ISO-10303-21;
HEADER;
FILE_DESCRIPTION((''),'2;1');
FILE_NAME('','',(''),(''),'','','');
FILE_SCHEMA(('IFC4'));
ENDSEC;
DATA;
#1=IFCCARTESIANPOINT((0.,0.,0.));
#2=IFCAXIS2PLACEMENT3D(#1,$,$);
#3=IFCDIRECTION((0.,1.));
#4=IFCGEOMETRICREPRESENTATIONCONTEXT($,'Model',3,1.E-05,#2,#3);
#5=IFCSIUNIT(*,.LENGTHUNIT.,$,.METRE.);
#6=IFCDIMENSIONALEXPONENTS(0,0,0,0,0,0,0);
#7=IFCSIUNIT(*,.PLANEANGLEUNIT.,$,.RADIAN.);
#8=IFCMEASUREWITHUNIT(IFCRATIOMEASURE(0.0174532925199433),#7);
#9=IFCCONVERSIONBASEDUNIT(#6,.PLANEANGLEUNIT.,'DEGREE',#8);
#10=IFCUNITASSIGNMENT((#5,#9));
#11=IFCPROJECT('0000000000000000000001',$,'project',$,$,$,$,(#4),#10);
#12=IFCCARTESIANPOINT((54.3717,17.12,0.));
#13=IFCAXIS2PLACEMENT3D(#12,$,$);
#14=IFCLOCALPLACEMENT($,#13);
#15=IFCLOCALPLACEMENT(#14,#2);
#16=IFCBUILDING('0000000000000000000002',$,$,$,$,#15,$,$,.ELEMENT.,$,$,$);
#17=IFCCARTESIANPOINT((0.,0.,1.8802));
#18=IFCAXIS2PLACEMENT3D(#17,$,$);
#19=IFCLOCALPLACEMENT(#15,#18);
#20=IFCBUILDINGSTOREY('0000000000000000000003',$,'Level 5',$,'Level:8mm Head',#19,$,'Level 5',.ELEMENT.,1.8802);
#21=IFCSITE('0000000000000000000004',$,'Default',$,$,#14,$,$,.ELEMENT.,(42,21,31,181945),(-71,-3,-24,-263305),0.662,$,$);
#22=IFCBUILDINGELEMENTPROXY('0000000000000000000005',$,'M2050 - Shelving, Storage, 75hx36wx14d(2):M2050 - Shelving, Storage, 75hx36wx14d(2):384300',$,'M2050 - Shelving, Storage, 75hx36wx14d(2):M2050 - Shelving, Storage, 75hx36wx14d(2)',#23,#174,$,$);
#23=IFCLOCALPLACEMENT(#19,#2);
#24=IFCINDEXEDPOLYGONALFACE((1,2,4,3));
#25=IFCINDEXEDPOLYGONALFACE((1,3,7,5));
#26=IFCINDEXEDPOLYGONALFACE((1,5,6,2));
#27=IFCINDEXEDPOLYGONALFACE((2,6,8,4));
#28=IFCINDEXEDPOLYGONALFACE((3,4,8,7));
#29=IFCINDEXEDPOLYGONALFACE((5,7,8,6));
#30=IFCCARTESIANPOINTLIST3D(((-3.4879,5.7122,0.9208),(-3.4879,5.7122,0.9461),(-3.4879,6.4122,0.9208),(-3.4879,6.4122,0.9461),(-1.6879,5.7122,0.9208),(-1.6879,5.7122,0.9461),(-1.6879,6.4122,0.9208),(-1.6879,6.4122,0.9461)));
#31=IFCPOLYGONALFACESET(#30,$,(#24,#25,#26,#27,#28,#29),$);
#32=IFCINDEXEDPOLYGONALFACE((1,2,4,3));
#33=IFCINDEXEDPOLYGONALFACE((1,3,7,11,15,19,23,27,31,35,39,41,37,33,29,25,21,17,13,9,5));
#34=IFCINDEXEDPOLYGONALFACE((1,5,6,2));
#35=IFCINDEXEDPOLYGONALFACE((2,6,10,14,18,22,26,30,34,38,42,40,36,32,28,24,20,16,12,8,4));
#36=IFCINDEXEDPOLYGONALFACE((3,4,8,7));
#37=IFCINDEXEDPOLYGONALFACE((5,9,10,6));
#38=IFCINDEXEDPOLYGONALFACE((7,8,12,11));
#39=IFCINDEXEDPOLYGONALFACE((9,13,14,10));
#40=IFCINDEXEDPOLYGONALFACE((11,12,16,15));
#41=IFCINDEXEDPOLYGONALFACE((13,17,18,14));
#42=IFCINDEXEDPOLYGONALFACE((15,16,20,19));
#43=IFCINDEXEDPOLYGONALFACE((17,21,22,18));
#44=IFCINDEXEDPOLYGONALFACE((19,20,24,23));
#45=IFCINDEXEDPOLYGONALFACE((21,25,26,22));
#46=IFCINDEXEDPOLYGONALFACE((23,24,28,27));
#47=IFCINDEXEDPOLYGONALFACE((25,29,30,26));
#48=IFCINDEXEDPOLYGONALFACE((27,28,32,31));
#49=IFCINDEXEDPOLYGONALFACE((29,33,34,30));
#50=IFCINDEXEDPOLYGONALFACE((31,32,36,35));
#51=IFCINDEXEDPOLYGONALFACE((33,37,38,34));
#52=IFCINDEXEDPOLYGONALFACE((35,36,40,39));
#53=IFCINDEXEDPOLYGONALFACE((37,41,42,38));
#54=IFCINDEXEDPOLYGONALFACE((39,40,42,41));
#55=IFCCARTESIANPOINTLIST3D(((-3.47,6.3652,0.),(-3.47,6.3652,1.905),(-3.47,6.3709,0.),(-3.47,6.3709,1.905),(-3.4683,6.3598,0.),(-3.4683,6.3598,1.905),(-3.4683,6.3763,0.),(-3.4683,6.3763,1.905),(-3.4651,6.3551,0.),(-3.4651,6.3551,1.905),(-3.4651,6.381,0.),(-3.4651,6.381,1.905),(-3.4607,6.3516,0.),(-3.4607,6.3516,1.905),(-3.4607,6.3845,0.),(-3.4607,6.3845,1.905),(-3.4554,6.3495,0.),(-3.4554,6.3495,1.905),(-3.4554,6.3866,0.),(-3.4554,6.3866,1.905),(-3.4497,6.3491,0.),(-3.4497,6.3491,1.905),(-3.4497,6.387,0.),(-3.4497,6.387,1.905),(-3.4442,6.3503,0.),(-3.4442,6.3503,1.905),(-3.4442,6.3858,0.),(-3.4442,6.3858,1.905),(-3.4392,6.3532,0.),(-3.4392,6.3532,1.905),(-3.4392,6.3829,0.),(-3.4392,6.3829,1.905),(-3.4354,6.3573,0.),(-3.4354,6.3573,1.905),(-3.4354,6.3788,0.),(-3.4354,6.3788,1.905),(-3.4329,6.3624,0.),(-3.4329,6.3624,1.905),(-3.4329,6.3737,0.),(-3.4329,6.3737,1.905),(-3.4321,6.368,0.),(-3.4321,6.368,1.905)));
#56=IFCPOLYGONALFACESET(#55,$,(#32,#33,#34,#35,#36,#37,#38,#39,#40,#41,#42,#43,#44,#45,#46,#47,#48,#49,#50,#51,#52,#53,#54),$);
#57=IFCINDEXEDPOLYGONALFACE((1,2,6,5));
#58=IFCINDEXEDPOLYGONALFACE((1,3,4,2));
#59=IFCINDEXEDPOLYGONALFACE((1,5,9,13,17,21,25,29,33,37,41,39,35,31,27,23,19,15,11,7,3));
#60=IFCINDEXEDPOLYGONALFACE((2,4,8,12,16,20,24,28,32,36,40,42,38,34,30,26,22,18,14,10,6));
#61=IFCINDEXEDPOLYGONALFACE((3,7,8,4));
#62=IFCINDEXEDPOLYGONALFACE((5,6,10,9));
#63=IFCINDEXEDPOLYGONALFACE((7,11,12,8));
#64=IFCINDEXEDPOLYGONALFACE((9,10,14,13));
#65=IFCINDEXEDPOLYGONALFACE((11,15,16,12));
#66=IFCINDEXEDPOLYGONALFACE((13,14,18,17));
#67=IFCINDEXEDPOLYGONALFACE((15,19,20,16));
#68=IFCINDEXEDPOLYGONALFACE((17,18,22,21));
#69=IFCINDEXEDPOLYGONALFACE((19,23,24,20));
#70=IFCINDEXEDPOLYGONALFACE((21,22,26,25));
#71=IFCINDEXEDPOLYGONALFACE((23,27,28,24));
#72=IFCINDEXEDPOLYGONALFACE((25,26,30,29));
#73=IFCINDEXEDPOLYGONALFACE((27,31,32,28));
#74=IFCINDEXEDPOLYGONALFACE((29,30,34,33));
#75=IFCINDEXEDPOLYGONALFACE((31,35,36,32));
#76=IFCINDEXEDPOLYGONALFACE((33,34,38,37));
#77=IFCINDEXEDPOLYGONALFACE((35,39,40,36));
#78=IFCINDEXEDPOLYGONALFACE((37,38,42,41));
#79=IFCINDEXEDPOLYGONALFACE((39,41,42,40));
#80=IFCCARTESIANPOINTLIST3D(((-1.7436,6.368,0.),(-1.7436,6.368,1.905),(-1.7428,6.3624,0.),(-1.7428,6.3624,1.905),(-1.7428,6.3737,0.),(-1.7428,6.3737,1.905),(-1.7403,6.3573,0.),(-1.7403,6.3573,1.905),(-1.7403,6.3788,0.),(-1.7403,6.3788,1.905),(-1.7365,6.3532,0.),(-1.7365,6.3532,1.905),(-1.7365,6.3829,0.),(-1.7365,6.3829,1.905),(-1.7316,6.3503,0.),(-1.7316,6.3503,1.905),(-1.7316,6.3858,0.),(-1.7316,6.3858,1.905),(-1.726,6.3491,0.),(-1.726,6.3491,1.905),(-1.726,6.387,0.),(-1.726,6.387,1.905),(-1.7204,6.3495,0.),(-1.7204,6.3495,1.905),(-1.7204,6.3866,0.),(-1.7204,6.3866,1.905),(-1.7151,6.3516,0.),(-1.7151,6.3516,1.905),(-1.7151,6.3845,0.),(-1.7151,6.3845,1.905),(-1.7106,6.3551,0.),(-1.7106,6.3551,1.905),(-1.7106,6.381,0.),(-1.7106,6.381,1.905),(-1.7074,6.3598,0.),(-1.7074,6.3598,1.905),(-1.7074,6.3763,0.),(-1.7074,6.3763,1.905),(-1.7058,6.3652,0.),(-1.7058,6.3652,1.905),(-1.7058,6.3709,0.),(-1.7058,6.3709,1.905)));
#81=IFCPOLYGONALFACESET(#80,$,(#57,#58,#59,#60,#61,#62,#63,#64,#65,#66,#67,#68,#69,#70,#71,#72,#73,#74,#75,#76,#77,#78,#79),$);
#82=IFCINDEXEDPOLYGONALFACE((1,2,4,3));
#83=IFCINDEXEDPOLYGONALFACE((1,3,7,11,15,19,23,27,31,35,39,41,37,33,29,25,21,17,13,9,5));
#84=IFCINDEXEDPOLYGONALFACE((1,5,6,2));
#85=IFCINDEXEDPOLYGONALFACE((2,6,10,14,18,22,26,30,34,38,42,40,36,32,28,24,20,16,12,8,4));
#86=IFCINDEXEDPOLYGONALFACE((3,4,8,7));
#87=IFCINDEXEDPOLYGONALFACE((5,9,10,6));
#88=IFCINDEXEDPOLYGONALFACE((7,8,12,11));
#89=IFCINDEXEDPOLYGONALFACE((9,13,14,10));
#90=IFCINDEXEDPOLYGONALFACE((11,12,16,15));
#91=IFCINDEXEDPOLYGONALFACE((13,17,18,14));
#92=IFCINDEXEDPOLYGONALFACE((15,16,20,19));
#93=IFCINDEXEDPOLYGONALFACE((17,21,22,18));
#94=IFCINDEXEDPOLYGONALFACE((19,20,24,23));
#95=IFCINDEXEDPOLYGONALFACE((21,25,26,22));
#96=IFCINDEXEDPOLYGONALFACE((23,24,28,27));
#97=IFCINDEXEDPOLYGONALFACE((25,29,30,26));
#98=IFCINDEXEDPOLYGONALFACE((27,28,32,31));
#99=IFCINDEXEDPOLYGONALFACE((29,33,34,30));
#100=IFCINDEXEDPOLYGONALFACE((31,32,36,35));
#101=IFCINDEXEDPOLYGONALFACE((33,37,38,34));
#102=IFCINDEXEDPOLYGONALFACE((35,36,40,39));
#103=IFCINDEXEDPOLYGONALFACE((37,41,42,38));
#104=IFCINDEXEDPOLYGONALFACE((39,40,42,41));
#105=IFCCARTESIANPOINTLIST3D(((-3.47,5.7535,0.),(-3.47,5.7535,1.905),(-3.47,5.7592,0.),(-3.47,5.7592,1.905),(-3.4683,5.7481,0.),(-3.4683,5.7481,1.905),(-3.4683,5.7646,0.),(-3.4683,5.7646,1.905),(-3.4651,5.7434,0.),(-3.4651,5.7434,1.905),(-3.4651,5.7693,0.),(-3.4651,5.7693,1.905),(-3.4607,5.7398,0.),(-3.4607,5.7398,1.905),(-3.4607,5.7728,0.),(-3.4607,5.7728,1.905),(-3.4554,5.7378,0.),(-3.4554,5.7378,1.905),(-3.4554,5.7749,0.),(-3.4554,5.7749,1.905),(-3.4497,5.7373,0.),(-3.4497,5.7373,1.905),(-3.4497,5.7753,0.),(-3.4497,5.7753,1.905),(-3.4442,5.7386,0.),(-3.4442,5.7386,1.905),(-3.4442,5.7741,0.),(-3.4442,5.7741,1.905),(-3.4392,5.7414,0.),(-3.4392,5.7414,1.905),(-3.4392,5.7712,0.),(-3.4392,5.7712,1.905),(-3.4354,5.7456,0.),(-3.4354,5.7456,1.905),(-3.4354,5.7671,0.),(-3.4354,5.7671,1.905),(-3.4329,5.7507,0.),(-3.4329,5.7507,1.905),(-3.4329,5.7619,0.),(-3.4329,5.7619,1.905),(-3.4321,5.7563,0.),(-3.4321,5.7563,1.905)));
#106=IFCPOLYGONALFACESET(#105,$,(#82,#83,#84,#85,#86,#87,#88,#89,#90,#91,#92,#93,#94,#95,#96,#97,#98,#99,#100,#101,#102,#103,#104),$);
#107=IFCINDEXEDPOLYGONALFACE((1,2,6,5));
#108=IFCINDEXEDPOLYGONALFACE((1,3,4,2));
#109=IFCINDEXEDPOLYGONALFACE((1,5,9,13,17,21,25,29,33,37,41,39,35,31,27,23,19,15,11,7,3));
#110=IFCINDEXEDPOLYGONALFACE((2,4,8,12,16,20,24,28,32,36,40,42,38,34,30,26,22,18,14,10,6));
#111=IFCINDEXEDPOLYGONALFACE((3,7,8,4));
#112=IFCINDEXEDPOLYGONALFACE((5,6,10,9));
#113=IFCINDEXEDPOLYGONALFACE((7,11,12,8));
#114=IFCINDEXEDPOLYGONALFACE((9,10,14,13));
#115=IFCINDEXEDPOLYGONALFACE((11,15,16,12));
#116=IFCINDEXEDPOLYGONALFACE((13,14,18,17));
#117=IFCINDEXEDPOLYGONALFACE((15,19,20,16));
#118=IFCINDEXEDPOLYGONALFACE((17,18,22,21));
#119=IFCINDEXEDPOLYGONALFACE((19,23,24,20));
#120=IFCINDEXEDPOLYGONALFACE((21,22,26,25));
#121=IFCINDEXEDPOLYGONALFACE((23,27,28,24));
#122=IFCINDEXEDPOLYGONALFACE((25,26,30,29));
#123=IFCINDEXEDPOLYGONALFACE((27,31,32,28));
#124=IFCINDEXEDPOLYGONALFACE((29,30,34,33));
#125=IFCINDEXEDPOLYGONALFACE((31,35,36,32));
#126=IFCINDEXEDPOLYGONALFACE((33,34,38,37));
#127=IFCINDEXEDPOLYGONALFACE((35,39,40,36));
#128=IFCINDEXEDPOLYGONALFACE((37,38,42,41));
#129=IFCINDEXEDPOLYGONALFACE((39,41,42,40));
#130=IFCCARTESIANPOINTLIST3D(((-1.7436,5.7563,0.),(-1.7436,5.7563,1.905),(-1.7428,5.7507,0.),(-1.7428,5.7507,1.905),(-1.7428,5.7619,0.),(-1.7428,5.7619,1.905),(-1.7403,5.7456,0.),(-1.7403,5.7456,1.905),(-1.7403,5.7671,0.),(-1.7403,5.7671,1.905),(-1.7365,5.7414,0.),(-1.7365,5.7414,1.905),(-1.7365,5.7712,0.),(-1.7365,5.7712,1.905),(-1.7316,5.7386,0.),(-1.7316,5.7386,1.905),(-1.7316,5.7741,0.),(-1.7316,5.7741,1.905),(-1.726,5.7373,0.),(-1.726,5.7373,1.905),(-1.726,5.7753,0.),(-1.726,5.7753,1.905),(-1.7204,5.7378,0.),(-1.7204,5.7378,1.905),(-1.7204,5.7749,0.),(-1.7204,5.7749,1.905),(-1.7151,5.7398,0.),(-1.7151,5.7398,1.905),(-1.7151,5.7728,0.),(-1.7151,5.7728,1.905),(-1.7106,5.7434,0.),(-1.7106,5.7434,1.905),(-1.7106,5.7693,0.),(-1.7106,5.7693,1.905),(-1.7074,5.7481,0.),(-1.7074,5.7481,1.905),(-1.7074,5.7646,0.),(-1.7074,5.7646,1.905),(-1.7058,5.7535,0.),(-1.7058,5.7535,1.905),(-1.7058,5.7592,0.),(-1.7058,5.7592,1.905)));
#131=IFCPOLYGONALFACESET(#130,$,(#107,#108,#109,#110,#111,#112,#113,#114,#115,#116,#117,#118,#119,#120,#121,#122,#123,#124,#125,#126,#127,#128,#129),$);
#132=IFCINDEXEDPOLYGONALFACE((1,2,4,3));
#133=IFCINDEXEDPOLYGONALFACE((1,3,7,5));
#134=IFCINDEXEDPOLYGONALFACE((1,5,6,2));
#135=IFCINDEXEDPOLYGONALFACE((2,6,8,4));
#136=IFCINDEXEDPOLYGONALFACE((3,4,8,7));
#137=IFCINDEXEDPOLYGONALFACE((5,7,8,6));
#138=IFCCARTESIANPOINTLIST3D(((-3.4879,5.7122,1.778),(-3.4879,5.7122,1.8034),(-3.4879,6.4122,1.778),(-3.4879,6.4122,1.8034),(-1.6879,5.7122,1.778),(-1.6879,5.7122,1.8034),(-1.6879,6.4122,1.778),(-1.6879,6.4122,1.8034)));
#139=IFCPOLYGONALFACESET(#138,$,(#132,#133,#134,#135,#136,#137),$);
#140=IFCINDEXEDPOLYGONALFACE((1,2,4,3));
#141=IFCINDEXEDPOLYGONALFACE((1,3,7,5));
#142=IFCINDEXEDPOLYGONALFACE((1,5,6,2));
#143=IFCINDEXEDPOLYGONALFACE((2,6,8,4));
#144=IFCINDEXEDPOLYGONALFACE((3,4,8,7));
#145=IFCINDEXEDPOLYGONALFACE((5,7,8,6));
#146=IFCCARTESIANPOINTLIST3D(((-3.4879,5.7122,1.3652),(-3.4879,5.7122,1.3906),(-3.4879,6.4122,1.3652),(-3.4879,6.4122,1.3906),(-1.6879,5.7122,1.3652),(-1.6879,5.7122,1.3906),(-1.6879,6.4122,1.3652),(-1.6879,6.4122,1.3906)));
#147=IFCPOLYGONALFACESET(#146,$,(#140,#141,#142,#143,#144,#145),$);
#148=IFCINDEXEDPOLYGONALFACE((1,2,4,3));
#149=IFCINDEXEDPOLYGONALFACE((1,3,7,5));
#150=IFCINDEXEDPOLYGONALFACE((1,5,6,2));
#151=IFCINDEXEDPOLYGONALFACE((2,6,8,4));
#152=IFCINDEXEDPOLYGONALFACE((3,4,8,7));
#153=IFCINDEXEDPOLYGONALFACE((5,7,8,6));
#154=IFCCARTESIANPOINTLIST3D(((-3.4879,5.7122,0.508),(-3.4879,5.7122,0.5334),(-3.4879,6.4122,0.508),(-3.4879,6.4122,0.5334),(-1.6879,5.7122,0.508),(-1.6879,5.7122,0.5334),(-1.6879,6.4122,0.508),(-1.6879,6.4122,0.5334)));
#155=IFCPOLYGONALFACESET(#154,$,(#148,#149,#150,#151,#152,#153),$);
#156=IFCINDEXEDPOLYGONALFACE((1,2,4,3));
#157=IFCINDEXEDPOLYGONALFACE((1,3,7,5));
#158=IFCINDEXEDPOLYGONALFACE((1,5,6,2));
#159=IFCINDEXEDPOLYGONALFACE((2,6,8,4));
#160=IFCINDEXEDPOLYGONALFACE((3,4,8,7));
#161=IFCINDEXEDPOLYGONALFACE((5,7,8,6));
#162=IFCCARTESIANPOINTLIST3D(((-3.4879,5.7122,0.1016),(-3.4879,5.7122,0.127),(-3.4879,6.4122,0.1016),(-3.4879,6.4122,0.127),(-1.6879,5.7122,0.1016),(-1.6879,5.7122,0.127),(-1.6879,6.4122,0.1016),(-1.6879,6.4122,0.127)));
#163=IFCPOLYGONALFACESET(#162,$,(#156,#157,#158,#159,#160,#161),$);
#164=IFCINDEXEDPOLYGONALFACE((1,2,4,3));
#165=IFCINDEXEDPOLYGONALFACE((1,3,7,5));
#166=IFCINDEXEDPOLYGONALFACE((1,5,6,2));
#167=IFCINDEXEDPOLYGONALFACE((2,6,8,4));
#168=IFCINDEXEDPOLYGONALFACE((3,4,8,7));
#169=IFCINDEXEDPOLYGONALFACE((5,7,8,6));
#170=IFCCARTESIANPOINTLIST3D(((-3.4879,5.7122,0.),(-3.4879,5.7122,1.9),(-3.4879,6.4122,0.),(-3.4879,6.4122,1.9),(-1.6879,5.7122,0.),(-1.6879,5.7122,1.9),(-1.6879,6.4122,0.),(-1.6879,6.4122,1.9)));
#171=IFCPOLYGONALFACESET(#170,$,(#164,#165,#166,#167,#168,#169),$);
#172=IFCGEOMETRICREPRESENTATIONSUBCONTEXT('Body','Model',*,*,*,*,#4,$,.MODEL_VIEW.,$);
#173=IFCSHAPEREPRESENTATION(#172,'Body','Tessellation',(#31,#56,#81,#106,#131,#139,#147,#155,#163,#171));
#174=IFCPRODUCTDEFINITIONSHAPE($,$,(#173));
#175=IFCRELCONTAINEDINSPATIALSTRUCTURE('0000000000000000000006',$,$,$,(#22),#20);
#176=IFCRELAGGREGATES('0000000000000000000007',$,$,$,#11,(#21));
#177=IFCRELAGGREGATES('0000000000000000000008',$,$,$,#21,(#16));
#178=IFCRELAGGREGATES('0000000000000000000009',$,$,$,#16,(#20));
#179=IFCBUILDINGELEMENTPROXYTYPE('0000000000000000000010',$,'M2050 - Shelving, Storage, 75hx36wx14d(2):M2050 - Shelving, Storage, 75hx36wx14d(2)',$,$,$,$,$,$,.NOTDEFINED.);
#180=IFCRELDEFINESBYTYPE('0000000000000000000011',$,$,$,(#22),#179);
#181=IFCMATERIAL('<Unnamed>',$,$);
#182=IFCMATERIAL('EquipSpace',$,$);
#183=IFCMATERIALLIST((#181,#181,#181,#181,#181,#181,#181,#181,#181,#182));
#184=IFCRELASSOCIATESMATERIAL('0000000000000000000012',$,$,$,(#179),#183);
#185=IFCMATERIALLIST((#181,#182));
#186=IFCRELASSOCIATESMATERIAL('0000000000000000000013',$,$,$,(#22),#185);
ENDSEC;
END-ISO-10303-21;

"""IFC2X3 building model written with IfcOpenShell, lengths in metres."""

from ifc_helpers import new_model, entity, si_unit, converted_unit, direction, frame, frame_2d, origin, origin_2d_with_axis, place, context, subcontext, project, spatial, rectangle, circle, extrude, source, transform, mapped, material, material_list, type_object, type_shapes, element, save


model = new_model("IFC2X3")

# Units and contexts
model_context = context("Model", 3, precision=1e-05, world=origin(), true_north=direction((0.0, 1.0)))
body_context = subcontext(model_context, "Body", "Model", "MODEL_VIEW")
ifc_project = project(units=[si_unit("LENGTHUNIT", "METRE"), converted_unit("PLANEANGLEUNIT", "DEGREE", entity("IfcRatioMeasure", 0.0174532925199433), si_unit("PLANEANGLEUNIT", "RADIAN"), dimensions=[0, 0, 0, 0, 0, 0, 0])], contexts=[model_context])

# Site, building, storey
site_placement = place(None, frame((54.3717, 17.12, 0.0)))
site = spatial("IfcSite", under=ifc_project, at=site_placement, Name="Default", CompositionType="ELEMENT", RefLatitude=(42, 21, 31, 181945), RefLongitude=(-71, -3, -24, -263305), RefElevation=0.662)
building_placement = place(site_placement, origin())
building = spatial("IfcBuilding", under=site, at=building_placement, CompositionType="ELEMENT")
storey_placement = place(building_placement, frame((0.0, 0.0, 1.8802)))
storey = spatial("IfcBuildingStorey", under=building, at=storey_placement, Name="Level 5", ObjectType="Level:8mm Head", LongName="Level 5", CompositionType="ELEMENT", Elevation=1.8802)

# Building element proxy
ifc_material_1 = material(Name="<Unnamed>")
ifc_material_2 = material(Name="EquipSpace")
ifc_material_list_1 = material_list([ifc_material_1, ifc_material_1, ifc_material_1, ifc_material_1, ifc_material_1, ifc_material_1, ifc_material_1, ifc_material_1, ifc_material_1, ifc_material_2])
building_element_proxy_type = type_object("IfcBuildingElementProxyType", Name="M2050 - Shelving, Storage, 75hx36wx14d(2):M2050 - Shelving, Storage, 75hx36wx14d(2)", PredefinedType="NOTDEFINED", material=ifc_material_list_1)
shared_shape = source(origin(), body_context, "Body", "SweptSolid", [
    extrude(rectangle(XDim=1.8, YDim=0.7, at=origin_2d_with_axis()), frame((0.0, 0.0, 0.9207), z_axis=(0.0, 0.0, 1.0), x_axis=(-1.0, 0.0, 0.0)), (0.0, 0.0, 1.0), 0.0254),
    extrude(circle(Radius=0.0191, at=origin_2d_with_axis()), frame((0.8633, -0.3059, 0.0), z_axis=(0.0, 0.0, 1.0), x_axis=(-1.0, 0.0, 0.0)), (0.0, 0.0, 1.0), 1.905),
    extrude(circle(Radius=0.0191, at=origin_2d_with_axis()), frame((-0.8633, -0.3059, 0.0)), (0.0, 0.0, 1.0), 1.905),
    extrude(circle(Radius=0.0191, at=origin_2d_with_axis()), frame((0.8633, 0.3059, 0.0), z_axis=(0.0, 0.0, 1.0), x_axis=(-1.0, 0.0, 0.0)), (0.0, 0.0, 1.0), 1.905),
    extrude(circle(Radius=0.0191, at=origin_2d_with_axis()), frame((-0.8633, 0.3059, 0.0)), (0.0, 0.0, 1.0), 1.905),
    extrude(rectangle(XDim=1.8, YDim=0.7, at=origin_2d_with_axis()), frame((0.0, 0.0, 1.778), z_axis=(0.0, 0.0, 1.0), x_axis=(-1.0, 0.0, 0.0)), (0.0, 0.0, 1.0), 0.0254),
    extrude(rectangle(XDim=1.8, YDim=0.7, at=origin_2d_with_axis()), frame((0.0, 0.0, 1.3653), z_axis=(0.0, 0.0, 1.0), x_axis=(-1.0, 0.0, 0.0)), (0.0, 0.0, 1.0), 0.0254),
    extrude(rectangle(XDim=1.8, YDim=0.7, at=origin_2d_with_axis()), frame((0.0, 0.0, 0.508), z_axis=(0.0, 0.0, 1.0), x_axis=(-1.0, 0.0, 0.0)), (0.0, 0.0, 1.0), 0.0254),
    extrude(rectangle(XDim=1.8, YDim=0.7, at=origin_2d_with_axis()), frame((0.0, 0.0, 0.1016), z_axis=(0.0, 0.0, 1.0), x_axis=(-1.0, 0.0, 0.0)), (0.0, 0.0, 1.0), 0.0254),
    extrude(rectangle(XDim=0.7, YDim=1.8, at=frame_2d((0.0, 0.18), x_axis=(1.0, 0.0))), frame((-0.18, 0.0, 0.0), z_axis=(0.0, 0.0, 1.0), x_axis=(0.0, -1.0, 0.0)), (0.0, 0.0, 1.0), 1.9),
])
type_shapes(building_element_proxy_type, [shared_shape])
ifc_material_list_2 = material_list([ifc_material_1, ifc_material_2])
proxy_1_placement = place(storey_placement, frame((-2.5879, 6.0622, 0.0), z_axis=(0.0, 0.0, 1.0), x_axis=(-1.0, 0.0, 0.0)))
element("IfcBuildingElementProxy", 1, at=proxy_1_placement, inside=storey, type_object=building_element_proxy_type, material=ifc_material_list_2, Name="M2050 - Shelving, Storage, 75hx36wx14d(2):M2050 - Shelving, Storage, 75hx36wx14d(2):384300", ObjectType="M2050 - Shelving, Storage, 75hx36wx14d(2):M2050 - Shelving, Storage, 75hx36wx14d(2)", context=body_context, shape_type="MappedRepresentation", body=[
    mapped(shared_shape, transform((0.0, 0.0, 0.0), scale=1.0)),
])

save(model, "model.ifc")
